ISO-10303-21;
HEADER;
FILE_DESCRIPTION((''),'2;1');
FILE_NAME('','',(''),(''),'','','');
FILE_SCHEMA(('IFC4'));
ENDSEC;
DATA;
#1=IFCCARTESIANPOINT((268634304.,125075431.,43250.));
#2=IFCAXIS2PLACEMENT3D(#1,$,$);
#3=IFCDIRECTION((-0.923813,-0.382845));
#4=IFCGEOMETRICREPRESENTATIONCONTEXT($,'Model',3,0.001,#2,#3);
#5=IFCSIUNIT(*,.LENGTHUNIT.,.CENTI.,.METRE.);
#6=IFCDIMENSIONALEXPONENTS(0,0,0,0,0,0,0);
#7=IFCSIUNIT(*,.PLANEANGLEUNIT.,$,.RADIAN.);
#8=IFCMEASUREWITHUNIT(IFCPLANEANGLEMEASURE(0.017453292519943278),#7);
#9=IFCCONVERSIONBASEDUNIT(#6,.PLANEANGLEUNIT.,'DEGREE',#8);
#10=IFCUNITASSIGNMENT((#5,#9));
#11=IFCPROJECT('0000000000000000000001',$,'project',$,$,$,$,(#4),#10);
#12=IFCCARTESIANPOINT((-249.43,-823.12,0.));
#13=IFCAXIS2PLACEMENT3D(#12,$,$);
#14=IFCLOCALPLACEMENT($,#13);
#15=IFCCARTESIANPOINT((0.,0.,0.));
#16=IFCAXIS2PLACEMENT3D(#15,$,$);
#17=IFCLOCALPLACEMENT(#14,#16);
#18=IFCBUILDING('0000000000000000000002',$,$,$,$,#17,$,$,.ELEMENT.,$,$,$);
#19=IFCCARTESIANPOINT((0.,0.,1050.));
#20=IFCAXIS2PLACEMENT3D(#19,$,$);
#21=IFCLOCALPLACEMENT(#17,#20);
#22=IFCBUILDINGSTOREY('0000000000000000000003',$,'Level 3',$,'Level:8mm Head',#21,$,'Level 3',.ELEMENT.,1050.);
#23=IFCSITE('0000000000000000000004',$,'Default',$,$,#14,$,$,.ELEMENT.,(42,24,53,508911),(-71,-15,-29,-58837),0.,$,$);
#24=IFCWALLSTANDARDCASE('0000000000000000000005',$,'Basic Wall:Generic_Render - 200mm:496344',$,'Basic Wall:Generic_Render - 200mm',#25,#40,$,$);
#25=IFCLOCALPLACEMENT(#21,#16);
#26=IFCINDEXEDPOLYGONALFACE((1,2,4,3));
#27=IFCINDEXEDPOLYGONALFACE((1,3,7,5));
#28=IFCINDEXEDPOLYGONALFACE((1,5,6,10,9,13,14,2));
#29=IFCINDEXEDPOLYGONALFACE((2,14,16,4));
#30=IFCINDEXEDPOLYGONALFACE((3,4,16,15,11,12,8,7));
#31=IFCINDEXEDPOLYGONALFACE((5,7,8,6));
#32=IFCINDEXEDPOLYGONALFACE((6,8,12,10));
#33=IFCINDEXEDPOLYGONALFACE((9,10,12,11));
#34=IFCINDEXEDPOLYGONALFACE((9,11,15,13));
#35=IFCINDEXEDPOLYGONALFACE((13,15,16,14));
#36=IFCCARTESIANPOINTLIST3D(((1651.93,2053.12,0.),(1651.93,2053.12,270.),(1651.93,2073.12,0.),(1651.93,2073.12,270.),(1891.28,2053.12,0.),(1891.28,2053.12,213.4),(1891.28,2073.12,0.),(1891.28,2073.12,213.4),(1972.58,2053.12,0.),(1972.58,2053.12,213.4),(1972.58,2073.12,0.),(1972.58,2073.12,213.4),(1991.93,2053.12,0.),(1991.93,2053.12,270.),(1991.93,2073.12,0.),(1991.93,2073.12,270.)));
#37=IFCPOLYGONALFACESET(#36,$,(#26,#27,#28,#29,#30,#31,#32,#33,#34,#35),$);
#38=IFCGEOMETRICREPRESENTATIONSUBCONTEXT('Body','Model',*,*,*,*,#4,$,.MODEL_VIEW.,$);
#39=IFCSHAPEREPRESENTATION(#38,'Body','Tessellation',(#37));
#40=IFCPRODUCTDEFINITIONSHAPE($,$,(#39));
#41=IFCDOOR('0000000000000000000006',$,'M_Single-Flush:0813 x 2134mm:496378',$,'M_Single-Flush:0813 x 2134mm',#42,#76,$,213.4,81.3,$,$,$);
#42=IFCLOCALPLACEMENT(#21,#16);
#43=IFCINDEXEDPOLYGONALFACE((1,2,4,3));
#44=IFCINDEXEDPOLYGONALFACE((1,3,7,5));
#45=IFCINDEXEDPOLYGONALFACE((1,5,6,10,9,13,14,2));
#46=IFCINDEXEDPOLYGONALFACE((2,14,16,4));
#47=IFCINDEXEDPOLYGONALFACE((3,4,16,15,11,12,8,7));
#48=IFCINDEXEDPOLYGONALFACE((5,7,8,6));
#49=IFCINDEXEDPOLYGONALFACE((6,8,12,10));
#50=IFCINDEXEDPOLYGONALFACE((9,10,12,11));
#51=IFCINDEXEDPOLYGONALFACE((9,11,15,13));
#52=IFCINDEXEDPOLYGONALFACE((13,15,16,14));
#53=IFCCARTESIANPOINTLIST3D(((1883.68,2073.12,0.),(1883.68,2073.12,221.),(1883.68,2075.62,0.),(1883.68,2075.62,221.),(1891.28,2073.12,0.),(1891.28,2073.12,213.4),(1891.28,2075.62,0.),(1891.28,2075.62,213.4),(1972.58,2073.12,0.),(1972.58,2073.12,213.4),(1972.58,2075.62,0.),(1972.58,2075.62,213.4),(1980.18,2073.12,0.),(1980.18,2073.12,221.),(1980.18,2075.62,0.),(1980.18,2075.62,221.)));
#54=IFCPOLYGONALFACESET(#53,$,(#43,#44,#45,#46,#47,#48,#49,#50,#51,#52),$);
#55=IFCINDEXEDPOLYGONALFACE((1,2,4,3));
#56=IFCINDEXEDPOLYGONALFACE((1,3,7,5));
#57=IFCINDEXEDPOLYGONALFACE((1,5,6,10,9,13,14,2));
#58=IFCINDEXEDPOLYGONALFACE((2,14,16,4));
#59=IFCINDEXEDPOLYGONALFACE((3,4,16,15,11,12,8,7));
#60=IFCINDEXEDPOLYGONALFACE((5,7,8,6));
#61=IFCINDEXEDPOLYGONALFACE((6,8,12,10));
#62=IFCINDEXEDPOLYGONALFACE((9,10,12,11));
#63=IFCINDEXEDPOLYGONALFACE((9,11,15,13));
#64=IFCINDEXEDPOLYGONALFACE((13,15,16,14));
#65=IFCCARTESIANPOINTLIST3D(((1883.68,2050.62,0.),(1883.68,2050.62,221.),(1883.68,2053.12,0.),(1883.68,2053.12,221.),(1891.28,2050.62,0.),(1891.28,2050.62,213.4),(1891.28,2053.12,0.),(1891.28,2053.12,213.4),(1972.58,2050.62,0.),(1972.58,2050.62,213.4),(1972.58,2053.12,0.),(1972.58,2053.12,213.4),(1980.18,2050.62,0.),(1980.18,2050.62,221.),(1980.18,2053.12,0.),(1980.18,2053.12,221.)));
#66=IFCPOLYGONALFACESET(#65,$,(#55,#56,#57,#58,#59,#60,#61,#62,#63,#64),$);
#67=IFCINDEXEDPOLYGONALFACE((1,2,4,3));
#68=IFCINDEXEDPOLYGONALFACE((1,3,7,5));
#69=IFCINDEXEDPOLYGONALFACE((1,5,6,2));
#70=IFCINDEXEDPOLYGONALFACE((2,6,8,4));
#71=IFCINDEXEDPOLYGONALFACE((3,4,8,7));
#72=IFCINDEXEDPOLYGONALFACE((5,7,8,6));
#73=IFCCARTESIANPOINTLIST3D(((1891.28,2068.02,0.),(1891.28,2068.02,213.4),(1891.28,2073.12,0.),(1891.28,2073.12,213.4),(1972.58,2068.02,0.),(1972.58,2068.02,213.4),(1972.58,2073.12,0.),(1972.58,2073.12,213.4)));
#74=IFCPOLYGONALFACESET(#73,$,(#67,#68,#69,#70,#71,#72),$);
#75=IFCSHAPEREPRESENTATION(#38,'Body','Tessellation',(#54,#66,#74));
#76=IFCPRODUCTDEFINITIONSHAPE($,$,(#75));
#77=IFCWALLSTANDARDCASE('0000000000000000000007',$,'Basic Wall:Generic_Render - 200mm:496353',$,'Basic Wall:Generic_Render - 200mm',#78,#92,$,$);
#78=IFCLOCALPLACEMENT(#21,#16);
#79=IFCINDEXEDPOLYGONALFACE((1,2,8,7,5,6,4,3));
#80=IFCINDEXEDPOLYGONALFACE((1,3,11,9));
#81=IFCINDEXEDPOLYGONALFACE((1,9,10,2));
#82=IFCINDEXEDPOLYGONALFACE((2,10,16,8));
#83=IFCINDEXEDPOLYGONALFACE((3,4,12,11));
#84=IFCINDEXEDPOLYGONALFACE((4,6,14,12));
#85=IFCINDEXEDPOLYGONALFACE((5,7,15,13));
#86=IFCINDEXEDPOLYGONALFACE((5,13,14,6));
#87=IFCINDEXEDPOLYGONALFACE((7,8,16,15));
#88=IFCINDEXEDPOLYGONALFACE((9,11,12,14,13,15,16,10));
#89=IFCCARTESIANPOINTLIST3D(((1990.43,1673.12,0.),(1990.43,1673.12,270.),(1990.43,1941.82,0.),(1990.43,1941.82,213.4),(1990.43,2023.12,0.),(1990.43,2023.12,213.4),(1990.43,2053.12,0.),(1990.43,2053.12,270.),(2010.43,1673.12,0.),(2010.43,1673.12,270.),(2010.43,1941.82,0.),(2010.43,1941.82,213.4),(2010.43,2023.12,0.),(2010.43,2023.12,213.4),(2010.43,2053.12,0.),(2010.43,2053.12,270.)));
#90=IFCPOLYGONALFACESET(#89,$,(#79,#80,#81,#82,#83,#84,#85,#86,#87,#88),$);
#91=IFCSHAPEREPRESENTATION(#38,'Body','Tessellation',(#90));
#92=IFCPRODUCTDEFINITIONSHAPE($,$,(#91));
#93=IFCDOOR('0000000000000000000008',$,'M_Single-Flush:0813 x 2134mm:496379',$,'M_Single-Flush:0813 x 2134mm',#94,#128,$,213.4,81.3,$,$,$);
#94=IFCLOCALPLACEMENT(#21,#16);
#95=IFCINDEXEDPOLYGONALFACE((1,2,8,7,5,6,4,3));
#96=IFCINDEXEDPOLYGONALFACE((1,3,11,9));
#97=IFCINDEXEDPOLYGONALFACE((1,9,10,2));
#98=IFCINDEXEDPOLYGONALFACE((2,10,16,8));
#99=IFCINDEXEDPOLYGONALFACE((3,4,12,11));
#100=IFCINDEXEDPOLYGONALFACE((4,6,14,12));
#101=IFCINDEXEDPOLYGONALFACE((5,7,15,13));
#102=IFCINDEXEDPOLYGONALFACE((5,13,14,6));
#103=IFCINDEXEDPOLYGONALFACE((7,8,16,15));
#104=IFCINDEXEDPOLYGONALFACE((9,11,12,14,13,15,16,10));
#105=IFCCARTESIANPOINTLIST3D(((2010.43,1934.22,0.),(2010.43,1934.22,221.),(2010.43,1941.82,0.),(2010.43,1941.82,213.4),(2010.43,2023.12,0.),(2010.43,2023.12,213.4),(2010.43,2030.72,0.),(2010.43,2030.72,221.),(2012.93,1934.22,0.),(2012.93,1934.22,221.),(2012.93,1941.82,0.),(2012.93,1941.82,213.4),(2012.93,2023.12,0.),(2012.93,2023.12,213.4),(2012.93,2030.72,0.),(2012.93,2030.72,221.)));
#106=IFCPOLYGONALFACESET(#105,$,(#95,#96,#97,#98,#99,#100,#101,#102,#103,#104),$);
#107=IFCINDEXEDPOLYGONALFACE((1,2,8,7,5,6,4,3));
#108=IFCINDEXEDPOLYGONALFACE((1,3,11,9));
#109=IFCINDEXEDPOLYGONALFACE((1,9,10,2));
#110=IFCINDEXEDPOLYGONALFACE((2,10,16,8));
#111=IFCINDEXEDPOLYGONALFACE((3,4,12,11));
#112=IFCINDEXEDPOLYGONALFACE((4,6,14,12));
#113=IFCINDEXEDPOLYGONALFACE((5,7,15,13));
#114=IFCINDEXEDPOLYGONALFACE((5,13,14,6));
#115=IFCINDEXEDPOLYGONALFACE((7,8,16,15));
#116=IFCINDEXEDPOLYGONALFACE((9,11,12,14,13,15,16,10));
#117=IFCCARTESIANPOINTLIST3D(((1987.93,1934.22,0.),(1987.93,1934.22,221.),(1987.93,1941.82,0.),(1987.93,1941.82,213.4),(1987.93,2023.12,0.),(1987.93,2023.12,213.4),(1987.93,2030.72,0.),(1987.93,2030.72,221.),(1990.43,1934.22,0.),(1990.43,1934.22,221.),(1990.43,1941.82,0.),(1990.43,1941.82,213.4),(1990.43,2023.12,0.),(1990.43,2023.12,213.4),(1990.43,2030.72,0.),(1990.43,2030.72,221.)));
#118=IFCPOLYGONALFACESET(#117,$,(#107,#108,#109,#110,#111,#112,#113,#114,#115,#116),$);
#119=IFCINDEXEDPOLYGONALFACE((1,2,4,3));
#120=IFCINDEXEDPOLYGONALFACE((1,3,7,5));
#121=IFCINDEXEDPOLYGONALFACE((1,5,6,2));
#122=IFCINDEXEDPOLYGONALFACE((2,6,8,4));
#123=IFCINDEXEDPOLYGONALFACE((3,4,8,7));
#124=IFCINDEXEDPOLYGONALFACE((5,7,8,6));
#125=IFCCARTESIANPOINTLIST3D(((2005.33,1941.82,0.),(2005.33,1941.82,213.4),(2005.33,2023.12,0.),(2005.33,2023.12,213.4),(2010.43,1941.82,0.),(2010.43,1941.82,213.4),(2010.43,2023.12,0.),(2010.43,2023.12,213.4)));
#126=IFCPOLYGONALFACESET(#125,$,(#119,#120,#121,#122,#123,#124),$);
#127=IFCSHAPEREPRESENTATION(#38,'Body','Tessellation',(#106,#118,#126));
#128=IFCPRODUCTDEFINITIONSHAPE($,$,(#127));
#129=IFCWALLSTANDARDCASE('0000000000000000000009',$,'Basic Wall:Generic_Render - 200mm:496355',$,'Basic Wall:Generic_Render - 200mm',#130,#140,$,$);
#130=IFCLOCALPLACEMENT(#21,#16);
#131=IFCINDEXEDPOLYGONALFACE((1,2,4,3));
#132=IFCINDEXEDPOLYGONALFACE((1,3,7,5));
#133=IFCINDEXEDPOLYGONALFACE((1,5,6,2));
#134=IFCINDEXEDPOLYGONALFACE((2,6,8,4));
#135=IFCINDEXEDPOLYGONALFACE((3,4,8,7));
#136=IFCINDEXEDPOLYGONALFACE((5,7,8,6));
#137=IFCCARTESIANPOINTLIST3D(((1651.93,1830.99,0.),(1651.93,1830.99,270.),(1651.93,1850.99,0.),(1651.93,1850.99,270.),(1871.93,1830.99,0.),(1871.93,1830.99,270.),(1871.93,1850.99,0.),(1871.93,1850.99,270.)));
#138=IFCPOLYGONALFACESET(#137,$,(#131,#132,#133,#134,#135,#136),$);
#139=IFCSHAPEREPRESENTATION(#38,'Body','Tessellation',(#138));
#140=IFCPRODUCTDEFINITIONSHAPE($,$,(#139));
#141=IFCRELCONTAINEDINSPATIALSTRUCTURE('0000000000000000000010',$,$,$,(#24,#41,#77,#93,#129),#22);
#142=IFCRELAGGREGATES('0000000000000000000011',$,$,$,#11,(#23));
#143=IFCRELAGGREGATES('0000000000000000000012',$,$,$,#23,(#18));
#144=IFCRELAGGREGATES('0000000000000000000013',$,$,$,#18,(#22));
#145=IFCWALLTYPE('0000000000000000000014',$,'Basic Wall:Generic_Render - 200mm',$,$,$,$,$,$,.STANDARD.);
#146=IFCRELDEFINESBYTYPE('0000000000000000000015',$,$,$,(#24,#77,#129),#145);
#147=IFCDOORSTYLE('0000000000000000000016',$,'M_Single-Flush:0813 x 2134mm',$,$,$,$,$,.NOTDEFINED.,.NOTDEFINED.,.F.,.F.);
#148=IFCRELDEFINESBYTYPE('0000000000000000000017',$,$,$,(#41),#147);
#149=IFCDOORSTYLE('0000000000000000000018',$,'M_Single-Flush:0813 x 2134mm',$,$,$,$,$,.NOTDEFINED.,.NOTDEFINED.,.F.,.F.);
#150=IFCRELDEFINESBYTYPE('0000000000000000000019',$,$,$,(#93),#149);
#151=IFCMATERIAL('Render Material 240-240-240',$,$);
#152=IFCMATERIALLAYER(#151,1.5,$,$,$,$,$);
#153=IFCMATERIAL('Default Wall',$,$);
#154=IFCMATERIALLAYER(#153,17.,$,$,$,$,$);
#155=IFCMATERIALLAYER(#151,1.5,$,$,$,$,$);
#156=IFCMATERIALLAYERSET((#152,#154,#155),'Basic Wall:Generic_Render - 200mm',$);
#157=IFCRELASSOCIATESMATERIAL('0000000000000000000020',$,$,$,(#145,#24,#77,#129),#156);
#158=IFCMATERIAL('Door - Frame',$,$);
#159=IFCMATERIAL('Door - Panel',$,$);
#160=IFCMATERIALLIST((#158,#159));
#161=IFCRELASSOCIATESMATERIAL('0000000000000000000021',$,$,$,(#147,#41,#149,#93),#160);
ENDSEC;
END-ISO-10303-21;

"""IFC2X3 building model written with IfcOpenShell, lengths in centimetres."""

from ifc_helpers import new_model, entity, si_unit, converted_unit, direction, frame, frame_2d, origin, place, context, subcontext, project, spatial, polyline, rectangle, outline, extrude, source, transform, mapped, material, material_list, layer, layer_set, layer_usage, type_object, type_shapes, element, fill, save


model = new_model("IFC2X3")

# Units and contexts
model_context = context("Model", 3, precision=0.001, world=frame((268634304.0, 125075431.0, 43250.0)), true_north=direction((-0.923813, -0.382845)))
body_context = subcontext(model_context, "Body", "Model", "MODEL_VIEW")
ifc_project = project(units=[si_unit("LENGTHUNIT", "METRE", prefix="CENTI"), converted_unit("PLANEANGLEUNIT", "DEGREE", entity("IfcPlaneAngleMeasure", 0.017453292519943278), si_unit("PLANEANGLEUNIT", "RADIAN"), dimensions=[0, 0, 0, 0, 0, 0, 0])], contexts=[model_context])

# Site, building, storey
site_placement = place(None, frame((-249.43, -823.12, 0.0)))
site = spatial("IfcSite", under=ifc_project, at=site_placement, Name="Default", CompositionType="ELEMENT", RefLatitude=(42, 24, 53, 508911), RefLongitude=(-71, -15, -29, -58837), RefElevation=0.0)
building_placement = place(site_placement, origin())
building = spatial("IfcBuilding", under=site, at=building_placement, CompositionType="ELEMENT")
storey_placement = place(building_placement, frame((0.0, 0.0, 1050.0)))
storey = spatial("IfcBuildingStorey", under=building, at=storey_placement, Name="Level 3", ObjectType="Level:8mm Head", LongName="Level 3", CompositionType="ELEMENT", Elevation=1050.0)

# Shared definitions
ifc_material_1 = material(Name="Render Material 240-240-240")
ifc_material_2 = material(Name="Default Wall")
ifc_layer_1 = layer(ifc_material_1, 1.5)
ifc_layer_2 = layer(ifc_material_2, 17.0)
ifc_layer_3 = layer(ifc_material_1, 1.5)
ifc_layer_set_1 = layer_set([ifc_layer_1, ifc_layer_2, ifc_layer_3], Name="Basic Wall:Generic_Render - 200mm")
wall_type_1 = type_object("IfcWallType", Name="Basic Wall:Generic_Render - 200mm", PredefinedType="STANDARD", material=ifc_layer_set_1)

# Walls, openings, doors
ifc_layer_usage_1 = layer_usage(ifc_layer_set_1, "AXIS2", "NEGATIVE", 10.0)
wall_1_placement = place(storey_placement, frame((1651.93, 2063.12, 0.0)))
wall_1 = element("IfcWallStandardCase", 1, at=wall_1_placement, inside=storey, type_object=wall_type_1, material=ifc_layer_usage_1, Name="Basic Wall:Generic_Render - 200mm:496344", ObjectType="Basic Wall:Generic_Render - 200mm", context=body_context, shape_type="SweptSolid", body=[
    extrude(rectangle(XDim=340.0, YDim=20.0, at=frame_2d((170.0, 0.0), x_axis=(1.0, 0.0))), origin(), (0.0, 0.0, 1.0), 270.0),
])
opening_1_placement = place(wall_1_placement, frame((239.35, -10.0, 0.0)))
opening_1 = element("IfcOpeningElement", 2, at=opening_1_placement, cuts=wall_1, ObjectType="Opening", context=body_context, shape_type="SweptSolid", body=[
    extrude(rectangle(XDim=81.3, YDim=213.4, at=frame_2d((106.7, 40.65), x_axis=(0.0, 1.0))), frame((0.0, 0.0, 0.0), z_axis=(0.0, 1.0, 0.0), x_axis=(0.0, 0.0, 1.0)), (0.0, 0.0, 1.0), 20.0),
])
ifc_material_3 = material(Name="Door - Frame")
ifc_material_4 = material(Name="Door - Panel")
ifc_material_list = material_list([ifc_material_3, ifc_material_4])
door_style_1 = type_object("IfcDoorStyle", Name="M_Single-Flush:0813 x 2134mm", ConstructionType="NOTDEFINED", OperationType="NOTDEFINED", ParameterTakesPrecedence=False, Sizeable=False, material=ifc_material_list)
shared_shape_1 = source(origin(), body_context, "Body", "SweptSolid", [
    extrude(outline(polyline([(-48.25, -112.4), (48.25, -112.4), (48.25, 108.6), (40.65, 108.6), (40.65, -104.8), (-40.65, -104.8), (-40.65, 108.6), (-48.25, 108.6), (-48.25, -112.4)])), frame((40.65, 20.0, 108.6), z_axis=(0.0, 1.0, 0.0), x_axis=(1.0, 0.0, 0.0)), (0.0, 0.0, 1.0), 2.5),
    extrude(outline(polyline([(-112.4, -48.25), (108.6, -48.25), (108.6, -40.65), (-104.8, -40.65), (-104.8, 40.65), (108.6, 40.65), (108.6, 48.25), (-112.4, 48.25), (-112.4, -48.25)])), frame((40.65, -2.5, 108.6), z_axis=(0.0, 1.0, 0.0), x_axis=(0.0, 0.0, -1.0)), (0.0, 0.0, 1.0), 2.5),
    extrude(rectangle(XDim=5.1, YDim=81.3, at=frame_2d((0.0, 0.0), x_axis=(1.0, 0.0))), frame((40.65, 17.45, 0.0), z_axis=(0.0, 0.0, 1.0), x_axis=(0.0, 1.0, 0.0)), (0.0, 0.0, 1.0), 213.4),
])
type_shapes(door_style_1, [shared_shape_1])
door_1_placement = place(opening_1_placement, origin())
door_1 = element("IfcDoor", 3, at=door_1_placement, inside=storey, type_object=door_style_1, material=ifc_material_list, Name="M_Single-Flush:0813 x 2134mm:496378", ObjectType="M_Single-Flush:0813 x 2134mm", OverallHeight=213.4, OverallWidth=81.3, context=body_context, shape_type="MappedRepresentation", body=[
    mapped(shared_shape_1, transform((0.0, 0.0, 0.0), scale=1.0)),
])
fill(opening_1, door_1)
ifc_layer_usage_2 = layer_usage(ifc_layer_set_1, "AXIS2", "NEGATIVE", 10.0)
wall_2_placement = place(storey_placement, frame((2000.43, 2053.12, 0.0), z_axis=(0.0, 0.0, 1.0), x_axis=(0.0, -1.0, 0.0)))
wall_2 = element("IfcWallStandardCase", 4, at=wall_2_placement, inside=storey, type_object=wall_type_1, material=ifc_layer_usage_2, Name="Basic Wall:Generic_Render - 200mm:496353", ObjectType="Basic Wall:Generic_Render - 200mm", context=body_context, shape_type="SweptSolid", body=[
    extrude(rectangle(XDim=380.0, YDim=20.0, at=frame_2d((190.0, 0.0), x_axis=(-1.0, 0.0))), origin(), (0.0, 0.0, 1.0), 270.0),
])
opening_2_placement = place(wall_2_placement, frame((30.0, -10.0, 0.0)))
opening_2 = element("IfcOpeningElement", 5, at=opening_2_placement, cuts=wall_2, ObjectType="Opening", context=body_context, shape_type="SweptSolid", body=[
    extrude(rectangle(XDim=81.3, YDim=213.4, at=frame_2d((106.7, 40.65), x_axis=(0.0, -1.0))), frame((0.0, 0.0, 0.0), z_axis=(0.0, 1.0, 0.0), x_axis=(0.0, 0.0, 1.0)), (0.0, 0.0, 1.0), 20.0),
])
door_style_2 = type_object("IfcDoorStyle", Name="M_Single-Flush:0813 x 2134mm", ConstructionType="NOTDEFINED", OperationType="NOTDEFINED", ParameterTakesPrecedence=False, Sizeable=False, material=ifc_material_list)
shared_shape_2 = source(origin(), body_context, "Body", "SweptSolid", [
    extrude(outline(polyline([(-48.25, -112.4), (48.25, -112.4), (48.25, 108.6), (40.65, 108.6), (40.65, -104.8), (-40.65, -104.8), (-40.65, 108.6), (-48.25, 108.6), (-48.25, -112.4)])), frame((40.65, 22.5, 108.6), z_axis=(0.0, -1.0, 0.0), x_axis=(-1.0, 0.0, 0.0)), (0.0, 0.0, 1.0), 2.5),
    extrude(outline(polyline([(-112.4, -48.25), (108.6, -48.25), (108.6, -40.65), (-104.8, -40.65), (-104.8, 40.65), (108.6, 40.65), (108.6, 48.25), (-112.4, 48.25), (-112.4, -48.25)])), frame((40.65, 0.0, 108.6), z_axis=(0.0, -1.0, 0.0), x_axis=(0.0, 0.0, -1.0)), (0.0, 0.0, 1.0), 2.5),
    extrude(rectangle(XDim=81.3, YDim=5.1, at=frame_2d((0.0, 0.0), x_axis=(1.0, 0.0))), frame((40.65, 17.45, 0.0)), (0.0, 0.0, 1.0), 213.4),
])
type_shapes(door_style_2, [shared_shape_2])
door_2_placement = place(opening_2_placement, origin())
door_2 = element("IfcDoor", 6, at=door_2_placement, inside=storey, type_object=door_style_2, material=ifc_material_list, Name="M_Single-Flush:0813 x 2134mm:496379", ObjectType="M_Single-Flush:0813 x 2134mm", OverallHeight=213.4, OverallWidth=81.3, context=body_context, shape_type="MappedRepresentation", body=[
    mapped(shared_shape_2, transform((0.0, 0.0, 0.0), scale=1.0)),
])
fill(opening_2, door_2)

# Wall
ifc_layer_usage_3 = layer_usage(ifc_layer_set_1, "AXIS2", "NEGATIVE", 10.0)
wall_3_placement = place(storey_placement, frame((1651.93, 1840.99, 0.0)))
element("IfcWallStandardCase", 7, at=wall_3_placement, inside=storey, type_object=wall_type_1, material=ifc_layer_usage_3, Name="Basic Wall:Generic_Render - 200mm:496355", ObjectType="Basic Wall:Generic_Render - 200mm", context=body_context, shape_type="SweptSolid", body=[
    extrude(rectangle(XDim=220.0, YDim=20.0, at=frame_2d((110.0, 0.0), x_axis=(-1.0, 0.0))), origin(), (0.0, 0.0, 1.0), 270.0),
])

save(model, "model.ifc")
